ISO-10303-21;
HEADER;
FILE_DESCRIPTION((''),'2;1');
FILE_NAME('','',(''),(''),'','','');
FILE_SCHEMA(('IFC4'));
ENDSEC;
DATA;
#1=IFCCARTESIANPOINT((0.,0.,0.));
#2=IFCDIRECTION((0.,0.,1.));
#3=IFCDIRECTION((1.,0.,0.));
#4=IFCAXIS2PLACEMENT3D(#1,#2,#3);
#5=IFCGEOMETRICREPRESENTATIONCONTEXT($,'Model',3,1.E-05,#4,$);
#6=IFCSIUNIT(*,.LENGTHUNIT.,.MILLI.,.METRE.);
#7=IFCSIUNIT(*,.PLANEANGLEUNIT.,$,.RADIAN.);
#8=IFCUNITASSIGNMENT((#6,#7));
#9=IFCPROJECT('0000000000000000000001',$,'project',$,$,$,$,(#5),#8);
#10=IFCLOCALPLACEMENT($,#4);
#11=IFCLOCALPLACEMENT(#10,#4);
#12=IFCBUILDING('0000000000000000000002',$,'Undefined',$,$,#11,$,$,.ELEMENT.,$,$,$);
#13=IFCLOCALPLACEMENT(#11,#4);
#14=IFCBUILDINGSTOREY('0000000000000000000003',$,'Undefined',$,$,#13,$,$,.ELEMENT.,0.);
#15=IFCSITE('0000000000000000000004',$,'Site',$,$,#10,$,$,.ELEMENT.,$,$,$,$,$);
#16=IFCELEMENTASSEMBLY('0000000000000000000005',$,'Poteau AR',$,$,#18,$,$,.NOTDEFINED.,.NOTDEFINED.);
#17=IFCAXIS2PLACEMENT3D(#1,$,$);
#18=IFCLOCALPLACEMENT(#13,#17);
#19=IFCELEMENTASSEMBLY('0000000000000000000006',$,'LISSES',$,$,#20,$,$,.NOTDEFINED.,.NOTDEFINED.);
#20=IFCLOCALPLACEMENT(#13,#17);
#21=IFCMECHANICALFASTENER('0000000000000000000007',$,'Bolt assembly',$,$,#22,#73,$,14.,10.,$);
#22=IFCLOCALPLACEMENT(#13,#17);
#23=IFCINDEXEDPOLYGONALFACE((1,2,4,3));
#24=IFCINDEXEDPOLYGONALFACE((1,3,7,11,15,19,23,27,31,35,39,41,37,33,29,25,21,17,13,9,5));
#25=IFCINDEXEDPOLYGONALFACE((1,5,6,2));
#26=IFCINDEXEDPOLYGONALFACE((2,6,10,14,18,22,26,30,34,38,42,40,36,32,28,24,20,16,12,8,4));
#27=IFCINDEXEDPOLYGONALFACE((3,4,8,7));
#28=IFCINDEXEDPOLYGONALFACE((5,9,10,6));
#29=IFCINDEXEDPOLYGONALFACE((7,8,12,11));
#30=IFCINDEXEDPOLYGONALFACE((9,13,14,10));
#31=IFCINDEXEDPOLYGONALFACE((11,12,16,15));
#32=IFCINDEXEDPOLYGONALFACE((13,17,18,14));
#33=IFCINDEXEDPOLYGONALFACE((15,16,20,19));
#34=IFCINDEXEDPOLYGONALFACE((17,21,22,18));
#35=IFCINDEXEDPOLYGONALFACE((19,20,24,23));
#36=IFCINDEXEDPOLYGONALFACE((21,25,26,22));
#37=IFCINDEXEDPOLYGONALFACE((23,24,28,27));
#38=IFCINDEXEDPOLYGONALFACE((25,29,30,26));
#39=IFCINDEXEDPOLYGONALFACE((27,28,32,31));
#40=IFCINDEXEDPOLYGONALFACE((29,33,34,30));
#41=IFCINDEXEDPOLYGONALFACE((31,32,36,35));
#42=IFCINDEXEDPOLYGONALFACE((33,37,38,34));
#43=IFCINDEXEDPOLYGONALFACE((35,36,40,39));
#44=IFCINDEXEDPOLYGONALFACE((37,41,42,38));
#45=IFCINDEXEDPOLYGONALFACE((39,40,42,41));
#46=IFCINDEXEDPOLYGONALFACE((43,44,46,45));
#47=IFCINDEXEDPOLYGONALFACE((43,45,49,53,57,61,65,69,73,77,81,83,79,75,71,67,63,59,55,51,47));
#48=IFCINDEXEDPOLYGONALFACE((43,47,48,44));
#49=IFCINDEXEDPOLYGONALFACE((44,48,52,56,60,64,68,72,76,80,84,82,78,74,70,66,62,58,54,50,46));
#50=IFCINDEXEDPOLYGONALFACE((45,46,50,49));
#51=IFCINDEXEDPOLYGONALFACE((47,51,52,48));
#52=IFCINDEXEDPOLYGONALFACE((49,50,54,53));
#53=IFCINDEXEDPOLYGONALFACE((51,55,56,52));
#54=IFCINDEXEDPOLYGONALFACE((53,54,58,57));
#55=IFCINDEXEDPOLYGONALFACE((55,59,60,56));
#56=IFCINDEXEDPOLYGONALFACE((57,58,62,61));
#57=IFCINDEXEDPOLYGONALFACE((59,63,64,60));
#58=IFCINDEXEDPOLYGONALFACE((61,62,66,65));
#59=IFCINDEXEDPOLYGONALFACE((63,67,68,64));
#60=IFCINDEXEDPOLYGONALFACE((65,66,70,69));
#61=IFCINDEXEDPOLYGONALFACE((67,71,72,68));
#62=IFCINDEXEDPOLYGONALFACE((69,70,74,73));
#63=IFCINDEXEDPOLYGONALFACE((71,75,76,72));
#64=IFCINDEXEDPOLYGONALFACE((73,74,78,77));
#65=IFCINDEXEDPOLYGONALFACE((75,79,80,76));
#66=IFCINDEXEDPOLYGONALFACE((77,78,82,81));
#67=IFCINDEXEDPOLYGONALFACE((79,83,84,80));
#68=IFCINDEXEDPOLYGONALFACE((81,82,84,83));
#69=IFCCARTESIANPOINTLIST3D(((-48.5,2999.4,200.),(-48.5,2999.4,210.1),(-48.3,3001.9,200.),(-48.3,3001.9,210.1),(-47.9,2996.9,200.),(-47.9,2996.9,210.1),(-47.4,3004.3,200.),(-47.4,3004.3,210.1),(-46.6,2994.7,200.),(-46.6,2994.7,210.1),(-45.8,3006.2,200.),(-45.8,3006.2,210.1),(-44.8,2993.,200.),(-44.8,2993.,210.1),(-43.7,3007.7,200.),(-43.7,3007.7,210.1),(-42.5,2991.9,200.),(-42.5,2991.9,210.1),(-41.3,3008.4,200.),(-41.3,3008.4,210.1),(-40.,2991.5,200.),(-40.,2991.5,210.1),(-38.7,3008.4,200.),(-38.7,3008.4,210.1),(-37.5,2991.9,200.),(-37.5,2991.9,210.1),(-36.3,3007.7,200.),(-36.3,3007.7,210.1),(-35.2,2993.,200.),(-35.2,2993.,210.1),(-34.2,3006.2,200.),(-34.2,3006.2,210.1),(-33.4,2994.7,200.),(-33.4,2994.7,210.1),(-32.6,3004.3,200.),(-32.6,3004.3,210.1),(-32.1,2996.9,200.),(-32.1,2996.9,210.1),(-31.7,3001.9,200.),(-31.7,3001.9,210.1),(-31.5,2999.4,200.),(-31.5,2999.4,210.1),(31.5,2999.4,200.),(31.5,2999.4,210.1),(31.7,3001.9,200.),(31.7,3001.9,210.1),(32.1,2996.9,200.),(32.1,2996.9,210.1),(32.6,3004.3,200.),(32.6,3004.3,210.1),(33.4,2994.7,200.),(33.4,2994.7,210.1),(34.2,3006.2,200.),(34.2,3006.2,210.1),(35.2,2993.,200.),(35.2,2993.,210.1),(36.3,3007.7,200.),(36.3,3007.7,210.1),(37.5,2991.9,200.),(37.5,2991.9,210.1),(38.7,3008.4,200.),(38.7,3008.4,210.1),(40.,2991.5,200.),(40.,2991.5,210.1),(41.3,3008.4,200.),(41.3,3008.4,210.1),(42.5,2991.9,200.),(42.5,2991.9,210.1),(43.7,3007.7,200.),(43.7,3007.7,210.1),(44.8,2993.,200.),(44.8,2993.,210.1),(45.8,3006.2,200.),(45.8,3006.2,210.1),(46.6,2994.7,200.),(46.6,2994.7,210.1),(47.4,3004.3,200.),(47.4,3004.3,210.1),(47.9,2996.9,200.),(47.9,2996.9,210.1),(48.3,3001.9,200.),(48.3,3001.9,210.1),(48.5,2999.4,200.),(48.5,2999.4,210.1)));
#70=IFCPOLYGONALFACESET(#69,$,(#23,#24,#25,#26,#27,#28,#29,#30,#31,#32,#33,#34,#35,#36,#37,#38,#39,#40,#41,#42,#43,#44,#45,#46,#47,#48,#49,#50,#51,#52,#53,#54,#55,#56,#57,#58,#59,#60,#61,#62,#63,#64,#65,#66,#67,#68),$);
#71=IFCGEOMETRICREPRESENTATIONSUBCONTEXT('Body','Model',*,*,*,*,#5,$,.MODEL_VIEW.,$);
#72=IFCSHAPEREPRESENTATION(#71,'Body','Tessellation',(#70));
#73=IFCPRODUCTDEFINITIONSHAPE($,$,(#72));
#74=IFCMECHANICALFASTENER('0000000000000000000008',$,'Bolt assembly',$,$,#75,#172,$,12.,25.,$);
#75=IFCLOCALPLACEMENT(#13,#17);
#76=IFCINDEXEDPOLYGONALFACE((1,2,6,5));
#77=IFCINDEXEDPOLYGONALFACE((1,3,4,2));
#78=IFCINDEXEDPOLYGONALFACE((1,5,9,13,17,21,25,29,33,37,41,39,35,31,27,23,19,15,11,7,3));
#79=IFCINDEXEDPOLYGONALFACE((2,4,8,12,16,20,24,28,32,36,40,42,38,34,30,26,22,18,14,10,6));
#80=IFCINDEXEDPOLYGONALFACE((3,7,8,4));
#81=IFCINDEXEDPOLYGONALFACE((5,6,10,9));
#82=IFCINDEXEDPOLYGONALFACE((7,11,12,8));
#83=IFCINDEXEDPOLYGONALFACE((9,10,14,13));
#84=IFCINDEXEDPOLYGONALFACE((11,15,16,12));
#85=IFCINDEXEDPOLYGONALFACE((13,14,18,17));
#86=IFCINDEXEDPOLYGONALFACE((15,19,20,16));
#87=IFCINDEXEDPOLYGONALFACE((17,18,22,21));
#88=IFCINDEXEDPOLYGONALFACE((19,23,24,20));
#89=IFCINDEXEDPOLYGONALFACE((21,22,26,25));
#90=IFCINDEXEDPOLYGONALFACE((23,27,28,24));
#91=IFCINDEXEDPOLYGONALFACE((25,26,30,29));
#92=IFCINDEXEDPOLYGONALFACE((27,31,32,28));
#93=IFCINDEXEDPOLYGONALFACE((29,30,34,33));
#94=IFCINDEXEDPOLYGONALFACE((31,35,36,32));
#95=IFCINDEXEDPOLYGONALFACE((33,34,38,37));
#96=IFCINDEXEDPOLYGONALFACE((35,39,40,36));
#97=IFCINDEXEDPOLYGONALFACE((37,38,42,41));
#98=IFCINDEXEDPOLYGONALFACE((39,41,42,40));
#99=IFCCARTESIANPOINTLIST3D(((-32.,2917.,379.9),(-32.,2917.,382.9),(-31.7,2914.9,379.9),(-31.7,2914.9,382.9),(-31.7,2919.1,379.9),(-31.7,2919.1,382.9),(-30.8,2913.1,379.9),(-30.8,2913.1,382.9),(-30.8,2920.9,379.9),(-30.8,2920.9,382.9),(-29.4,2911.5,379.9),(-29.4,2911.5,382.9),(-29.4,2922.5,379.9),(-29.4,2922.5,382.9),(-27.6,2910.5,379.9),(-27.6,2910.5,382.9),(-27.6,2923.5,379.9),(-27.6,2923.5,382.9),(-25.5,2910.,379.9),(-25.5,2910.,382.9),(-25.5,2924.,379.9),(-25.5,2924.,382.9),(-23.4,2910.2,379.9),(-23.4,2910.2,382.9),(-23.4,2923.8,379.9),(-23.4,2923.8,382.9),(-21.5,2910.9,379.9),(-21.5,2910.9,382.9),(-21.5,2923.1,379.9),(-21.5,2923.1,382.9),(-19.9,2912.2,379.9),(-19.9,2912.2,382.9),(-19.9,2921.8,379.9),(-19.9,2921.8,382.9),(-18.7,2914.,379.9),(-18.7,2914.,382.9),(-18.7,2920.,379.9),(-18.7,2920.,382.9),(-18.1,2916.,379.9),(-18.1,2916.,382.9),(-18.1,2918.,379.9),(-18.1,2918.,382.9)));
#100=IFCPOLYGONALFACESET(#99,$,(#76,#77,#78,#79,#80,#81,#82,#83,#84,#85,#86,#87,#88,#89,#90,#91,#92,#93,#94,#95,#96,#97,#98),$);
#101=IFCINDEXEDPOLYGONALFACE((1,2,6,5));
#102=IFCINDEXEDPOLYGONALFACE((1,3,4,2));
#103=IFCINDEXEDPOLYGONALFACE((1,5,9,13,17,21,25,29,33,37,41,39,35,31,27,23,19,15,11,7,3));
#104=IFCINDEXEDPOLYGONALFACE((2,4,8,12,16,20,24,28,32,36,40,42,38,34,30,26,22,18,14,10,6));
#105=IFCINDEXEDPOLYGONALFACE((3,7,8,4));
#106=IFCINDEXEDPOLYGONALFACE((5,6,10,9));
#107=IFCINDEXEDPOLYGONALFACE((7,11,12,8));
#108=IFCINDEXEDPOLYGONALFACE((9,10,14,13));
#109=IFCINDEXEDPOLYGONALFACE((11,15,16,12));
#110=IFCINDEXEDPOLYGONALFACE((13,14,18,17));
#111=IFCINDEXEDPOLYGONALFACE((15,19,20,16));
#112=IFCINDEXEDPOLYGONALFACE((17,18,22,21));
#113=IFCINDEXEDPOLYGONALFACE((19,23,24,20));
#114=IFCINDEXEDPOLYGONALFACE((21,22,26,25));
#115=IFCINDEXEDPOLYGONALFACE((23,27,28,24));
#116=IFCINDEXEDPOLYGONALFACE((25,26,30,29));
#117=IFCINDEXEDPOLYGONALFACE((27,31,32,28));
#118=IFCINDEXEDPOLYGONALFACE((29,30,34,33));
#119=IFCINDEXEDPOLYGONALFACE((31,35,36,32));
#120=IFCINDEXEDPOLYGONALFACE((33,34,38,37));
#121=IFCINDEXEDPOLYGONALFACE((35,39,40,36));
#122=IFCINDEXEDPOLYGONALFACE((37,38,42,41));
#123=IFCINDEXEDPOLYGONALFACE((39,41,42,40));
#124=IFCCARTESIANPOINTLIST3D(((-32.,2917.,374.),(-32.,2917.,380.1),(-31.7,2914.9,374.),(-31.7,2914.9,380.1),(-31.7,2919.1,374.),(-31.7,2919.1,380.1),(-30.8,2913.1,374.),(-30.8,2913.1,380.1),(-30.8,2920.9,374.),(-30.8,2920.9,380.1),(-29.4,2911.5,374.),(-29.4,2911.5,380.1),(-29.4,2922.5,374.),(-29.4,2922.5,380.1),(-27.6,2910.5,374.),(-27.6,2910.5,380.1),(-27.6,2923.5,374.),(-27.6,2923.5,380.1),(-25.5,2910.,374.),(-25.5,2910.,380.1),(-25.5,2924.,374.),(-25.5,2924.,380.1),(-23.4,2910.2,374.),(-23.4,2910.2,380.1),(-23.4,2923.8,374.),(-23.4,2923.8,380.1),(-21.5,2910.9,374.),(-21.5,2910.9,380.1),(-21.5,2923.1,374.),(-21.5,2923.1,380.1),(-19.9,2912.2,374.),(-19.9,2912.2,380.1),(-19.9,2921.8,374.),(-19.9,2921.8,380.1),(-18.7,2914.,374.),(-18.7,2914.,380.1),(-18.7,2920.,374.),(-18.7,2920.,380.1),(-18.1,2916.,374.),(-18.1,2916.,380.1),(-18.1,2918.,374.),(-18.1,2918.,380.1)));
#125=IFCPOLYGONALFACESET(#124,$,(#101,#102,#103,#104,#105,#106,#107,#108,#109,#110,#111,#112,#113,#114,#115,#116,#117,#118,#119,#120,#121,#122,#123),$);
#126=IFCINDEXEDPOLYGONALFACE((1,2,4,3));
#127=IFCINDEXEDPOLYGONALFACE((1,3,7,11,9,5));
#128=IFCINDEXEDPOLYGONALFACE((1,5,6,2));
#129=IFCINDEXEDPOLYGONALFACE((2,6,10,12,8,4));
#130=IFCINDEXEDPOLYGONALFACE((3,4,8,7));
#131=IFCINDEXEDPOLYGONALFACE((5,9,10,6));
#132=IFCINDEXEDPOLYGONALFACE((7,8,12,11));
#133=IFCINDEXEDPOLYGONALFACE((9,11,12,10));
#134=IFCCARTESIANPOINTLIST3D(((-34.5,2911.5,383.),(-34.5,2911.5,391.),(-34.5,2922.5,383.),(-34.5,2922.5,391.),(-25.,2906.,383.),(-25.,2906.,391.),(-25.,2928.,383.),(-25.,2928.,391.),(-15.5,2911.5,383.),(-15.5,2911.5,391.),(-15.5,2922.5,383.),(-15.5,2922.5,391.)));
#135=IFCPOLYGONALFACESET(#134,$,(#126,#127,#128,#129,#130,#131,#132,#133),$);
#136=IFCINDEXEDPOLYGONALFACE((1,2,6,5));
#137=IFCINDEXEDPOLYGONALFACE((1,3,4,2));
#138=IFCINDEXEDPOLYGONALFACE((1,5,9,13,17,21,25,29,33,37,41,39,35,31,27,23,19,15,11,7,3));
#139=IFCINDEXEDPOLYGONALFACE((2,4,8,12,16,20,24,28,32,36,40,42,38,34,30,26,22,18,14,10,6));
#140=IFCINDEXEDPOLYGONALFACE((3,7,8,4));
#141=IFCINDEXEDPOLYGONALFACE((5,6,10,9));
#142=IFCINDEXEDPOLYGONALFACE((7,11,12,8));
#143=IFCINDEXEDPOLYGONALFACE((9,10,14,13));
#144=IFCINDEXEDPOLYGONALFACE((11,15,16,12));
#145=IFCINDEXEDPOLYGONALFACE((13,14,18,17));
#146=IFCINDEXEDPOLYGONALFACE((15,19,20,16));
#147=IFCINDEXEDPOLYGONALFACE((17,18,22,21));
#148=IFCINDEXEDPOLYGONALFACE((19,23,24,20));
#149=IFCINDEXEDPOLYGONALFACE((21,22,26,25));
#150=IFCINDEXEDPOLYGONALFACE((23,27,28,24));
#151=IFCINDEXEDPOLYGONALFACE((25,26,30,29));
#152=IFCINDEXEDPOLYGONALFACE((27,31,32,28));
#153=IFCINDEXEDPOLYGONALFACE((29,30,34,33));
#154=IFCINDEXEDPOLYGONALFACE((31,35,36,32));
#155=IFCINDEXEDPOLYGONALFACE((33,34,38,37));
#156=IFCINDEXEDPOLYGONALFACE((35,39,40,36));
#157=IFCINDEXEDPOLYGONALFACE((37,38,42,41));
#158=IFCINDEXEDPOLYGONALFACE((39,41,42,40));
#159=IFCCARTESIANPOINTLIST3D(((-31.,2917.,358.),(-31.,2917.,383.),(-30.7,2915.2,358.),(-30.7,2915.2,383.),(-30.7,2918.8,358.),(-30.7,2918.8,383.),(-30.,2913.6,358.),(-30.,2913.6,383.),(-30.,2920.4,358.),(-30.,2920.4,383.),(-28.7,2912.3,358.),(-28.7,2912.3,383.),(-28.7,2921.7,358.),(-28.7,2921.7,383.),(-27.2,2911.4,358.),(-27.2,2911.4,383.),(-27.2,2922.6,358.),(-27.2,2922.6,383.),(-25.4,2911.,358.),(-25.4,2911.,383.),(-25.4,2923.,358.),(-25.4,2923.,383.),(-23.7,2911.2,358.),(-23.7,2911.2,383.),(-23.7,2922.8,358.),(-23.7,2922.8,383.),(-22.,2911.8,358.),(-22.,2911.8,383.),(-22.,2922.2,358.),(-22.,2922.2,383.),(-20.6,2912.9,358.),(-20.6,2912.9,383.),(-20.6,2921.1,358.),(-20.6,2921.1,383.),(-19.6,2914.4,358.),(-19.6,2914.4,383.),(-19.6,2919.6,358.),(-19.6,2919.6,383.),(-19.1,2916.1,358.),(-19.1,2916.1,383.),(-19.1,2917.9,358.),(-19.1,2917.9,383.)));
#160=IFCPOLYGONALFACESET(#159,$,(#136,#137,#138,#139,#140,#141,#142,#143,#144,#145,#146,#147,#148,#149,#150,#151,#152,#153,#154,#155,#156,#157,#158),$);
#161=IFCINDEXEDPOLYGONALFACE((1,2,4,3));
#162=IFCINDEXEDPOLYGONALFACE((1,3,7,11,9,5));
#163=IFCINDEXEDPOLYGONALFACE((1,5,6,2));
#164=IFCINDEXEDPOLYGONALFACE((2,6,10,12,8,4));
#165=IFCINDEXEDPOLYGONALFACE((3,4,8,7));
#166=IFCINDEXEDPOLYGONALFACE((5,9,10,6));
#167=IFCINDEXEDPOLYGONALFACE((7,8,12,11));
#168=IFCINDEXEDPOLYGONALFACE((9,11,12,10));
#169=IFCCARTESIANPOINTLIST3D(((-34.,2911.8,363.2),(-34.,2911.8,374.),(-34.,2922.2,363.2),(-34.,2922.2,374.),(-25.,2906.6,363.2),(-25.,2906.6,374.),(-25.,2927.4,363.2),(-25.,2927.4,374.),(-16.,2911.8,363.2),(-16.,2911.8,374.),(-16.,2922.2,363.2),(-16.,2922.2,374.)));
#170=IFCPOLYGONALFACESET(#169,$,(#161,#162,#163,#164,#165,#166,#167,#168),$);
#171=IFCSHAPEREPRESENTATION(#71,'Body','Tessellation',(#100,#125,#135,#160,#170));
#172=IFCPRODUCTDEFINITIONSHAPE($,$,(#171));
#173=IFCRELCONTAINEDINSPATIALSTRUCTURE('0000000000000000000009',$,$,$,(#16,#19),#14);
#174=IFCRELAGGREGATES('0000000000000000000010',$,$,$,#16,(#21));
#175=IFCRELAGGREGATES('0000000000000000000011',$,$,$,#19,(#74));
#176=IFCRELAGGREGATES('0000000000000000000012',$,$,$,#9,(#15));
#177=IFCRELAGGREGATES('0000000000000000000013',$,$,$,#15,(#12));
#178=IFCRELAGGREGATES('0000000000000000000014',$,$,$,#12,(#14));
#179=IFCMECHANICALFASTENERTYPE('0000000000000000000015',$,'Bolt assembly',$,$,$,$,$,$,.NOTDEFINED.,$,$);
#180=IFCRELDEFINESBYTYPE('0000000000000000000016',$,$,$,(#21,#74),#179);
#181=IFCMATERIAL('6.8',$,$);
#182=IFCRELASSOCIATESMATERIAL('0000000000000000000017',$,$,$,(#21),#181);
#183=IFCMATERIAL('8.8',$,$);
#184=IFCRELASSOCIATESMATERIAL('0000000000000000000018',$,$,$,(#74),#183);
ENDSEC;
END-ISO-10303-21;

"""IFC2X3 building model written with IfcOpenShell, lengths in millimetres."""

from ifc_helpers import new_model, si_unit, frame, origin_with_axes, origin_2d_with_axis, place, context, subcontext, project, spatial, polyline, circle, outline, extrude, source, transform, mapped, material, type_object, element, aggregate, save


model = new_model("IFC2X3")

# Units and contexts
model_context = context("Model", 3, precision=1e-05, world=origin_with_axes())
body_context = subcontext(model_context, "Body", "Model", "MODEL_VIEW")
ifc_project = project(units=[si_unit("LENGTHUNIT", "METRE", prefix="MILLI"), si_unit("PLANEANGLEUNIT", "RADIAN")], contexts=[model_context])

# Site, building, storey
site_placement = place(None, origin_with_axes())
site = spatial("IfcSite", under=ifc_project, at=site_placement, Name="Site", CompositionType="ELEMENT")
building_placement = place(site_placement, origin_with_axes())
building = spatial("IfcBuilding", under=site, at=building_placement, Name="Undefined", CompositionType="ELEMENT")
storey_placement = place(building_placement, origin_with_axes())
storey = spatial("IfcBuildingStorey", under=building, at=storey_placement, Name="Undefined", CompositionType="ELEMENT", Elevation=0.0)

# Element assembly
assembly_1_placement = place(storey_placement, origin_with_axes())
assembly_1 = element("IfcElementAssembly", 1, at=assembly_1_placement, inside=storey, Name="Poteau AR", AssemblyPlace="NOTDEFINED", PredefinedType="NOTDEFINED")

# Element assembly
assembly_2_placement = place(storey_placement, origin_with_axes())
assembly_2 = element("IfcElementAssembly", 2, at=assembly_2_placement, inside=storey, Name="LISSES", AssemblyPlace="NOTDEFINED", PredefinedType="NOTDEFINED")

# Mechanical fasteners
ifc_material_1 = material(Name="6.8")
mechanical_fastener_type = type_object("IfcMechanicalFastenerType", Name="Bolt assembly")
shared_shape_1 = source(origin_with_axes(), body_context, "Body", "SweptSolid", [
    extrude(circle(Radius=8.5, at=origin_2d_with_axis()), frame((0.0, -10.0, 0.0), z_axis=(0.0, 1.0, 0.0), x_axis=(1.0, 0.0, 0.0)), (0.0, 0.0, 1.0), 10.1),
])
mechanical_fastener_1_placement = place(assembly_1_placement, frame((0.0, 3048.0, 210.0), z_axis=(-1.0, 0.0, 0.0), x_axis=(0.0, -1.0, 0.0)))
mechanical_fastener_1 = element("IfcMechanicalFastener", 3, at=mechanical_fastener_1_placement, type_object=mechanical_fastener_type, material=ifc_material_1, Name="Bolt assembly", NominalDiameter=14.0, NominalLength=10.0, context=body_context, shape_type="MappedRepresentation", body=[
    mapped(shared_shape_1, transform((48.0, 0.0, -40.0))),
    mapped(shared_shape_1, transform((48.0, 0.0, 40.0))),
])
aggregate(assembly_1, [mechanical_fastener_1])
ifc_material_2 = material(Name="8.8")
shared_shape_2 = source(origin_with_axes(), body_context, "Body", "SweptSolid", [
    extrude(circle(Radius=7.0, at=origin_2d_with_axis()), frame((0.0, -2.9, 0.0), z_axis=(0.0, 1.0, 0.0), x_axis=(1.0, 0.0, 0.0)), (0.0, 0.0, 1.0), 3.0),
    extrude(circle(Radius=7.0, at=origin_2d_with_axis()), frame((0.0, -0.1, 0.0), z_axis=(0.0, 1.0, 0.0), x_axis=(1.0, 0.0, 0.0)), (0.0, 0.0, 1.0), 6.1),
    extrude(outline(polyline([(9.5, -5.5), (9.5, 5.5), (0.0, 11.0), (-9.5, 5.5), (-9.5, -5.5), (0.0, -11.0), (9.5, -5.5)])), frame((0.0, -11.0, 0.0), z_axis=(0.0, 1.0, 0.0), x_axis=(1.0, 0.0, 0.0)), (0.0, 0.0, 1.0), 8.0),
    extrude(circle(Radius=6.0, at=origin_2d_with_axis()), frame((0.0, -3.0, 0.0), z_axis=(0.0, 1.0, 0.0), x_axis=(1.0, 0.0, 0.0)), (0.0, 0.0, 1.0), 25.0),
    extrude(outline(polyline([(9.0, -5.2), (9.0, 5.2), (0.0, 10.4), (-9.0, 5.2), (-9.0, -5.2), (0.0, -10.4), (9.0, -5.2)])), frame((0.0, 6.0, 0.0), z_axis=(0.0, 1.0, 0.0), x_axis=(1.0, 0.0, 0.0)), (0.0, 0.0, 1.0), 10.8),
])
mechanical_fastener_2_placement = place(assembly_2_placement, frame((-25.0, 2917.0, 380.0), z_axis=(0.0, -1.0, 0.0), x_axis=(-1.0, 0.0, 0.0)))
mechanical_fastener_2 = element("IfcMechanicalFastener", 4, at=mechanical_fastener_2_placement, type_object=mechanical_fastener_type, material=ifc_material_2, Name="Bolt assembly", NominalDiameter=12.0, NominalLength=25.0, context=body_context, shape_type="MappedRepresentation", body=[
    mapped(shared_shape_2, transform((0.0, 0.0, 0.0))),
])
aggregate(assembly_2, [mechanical_fastener_2])

save(model, "model.ifc")
